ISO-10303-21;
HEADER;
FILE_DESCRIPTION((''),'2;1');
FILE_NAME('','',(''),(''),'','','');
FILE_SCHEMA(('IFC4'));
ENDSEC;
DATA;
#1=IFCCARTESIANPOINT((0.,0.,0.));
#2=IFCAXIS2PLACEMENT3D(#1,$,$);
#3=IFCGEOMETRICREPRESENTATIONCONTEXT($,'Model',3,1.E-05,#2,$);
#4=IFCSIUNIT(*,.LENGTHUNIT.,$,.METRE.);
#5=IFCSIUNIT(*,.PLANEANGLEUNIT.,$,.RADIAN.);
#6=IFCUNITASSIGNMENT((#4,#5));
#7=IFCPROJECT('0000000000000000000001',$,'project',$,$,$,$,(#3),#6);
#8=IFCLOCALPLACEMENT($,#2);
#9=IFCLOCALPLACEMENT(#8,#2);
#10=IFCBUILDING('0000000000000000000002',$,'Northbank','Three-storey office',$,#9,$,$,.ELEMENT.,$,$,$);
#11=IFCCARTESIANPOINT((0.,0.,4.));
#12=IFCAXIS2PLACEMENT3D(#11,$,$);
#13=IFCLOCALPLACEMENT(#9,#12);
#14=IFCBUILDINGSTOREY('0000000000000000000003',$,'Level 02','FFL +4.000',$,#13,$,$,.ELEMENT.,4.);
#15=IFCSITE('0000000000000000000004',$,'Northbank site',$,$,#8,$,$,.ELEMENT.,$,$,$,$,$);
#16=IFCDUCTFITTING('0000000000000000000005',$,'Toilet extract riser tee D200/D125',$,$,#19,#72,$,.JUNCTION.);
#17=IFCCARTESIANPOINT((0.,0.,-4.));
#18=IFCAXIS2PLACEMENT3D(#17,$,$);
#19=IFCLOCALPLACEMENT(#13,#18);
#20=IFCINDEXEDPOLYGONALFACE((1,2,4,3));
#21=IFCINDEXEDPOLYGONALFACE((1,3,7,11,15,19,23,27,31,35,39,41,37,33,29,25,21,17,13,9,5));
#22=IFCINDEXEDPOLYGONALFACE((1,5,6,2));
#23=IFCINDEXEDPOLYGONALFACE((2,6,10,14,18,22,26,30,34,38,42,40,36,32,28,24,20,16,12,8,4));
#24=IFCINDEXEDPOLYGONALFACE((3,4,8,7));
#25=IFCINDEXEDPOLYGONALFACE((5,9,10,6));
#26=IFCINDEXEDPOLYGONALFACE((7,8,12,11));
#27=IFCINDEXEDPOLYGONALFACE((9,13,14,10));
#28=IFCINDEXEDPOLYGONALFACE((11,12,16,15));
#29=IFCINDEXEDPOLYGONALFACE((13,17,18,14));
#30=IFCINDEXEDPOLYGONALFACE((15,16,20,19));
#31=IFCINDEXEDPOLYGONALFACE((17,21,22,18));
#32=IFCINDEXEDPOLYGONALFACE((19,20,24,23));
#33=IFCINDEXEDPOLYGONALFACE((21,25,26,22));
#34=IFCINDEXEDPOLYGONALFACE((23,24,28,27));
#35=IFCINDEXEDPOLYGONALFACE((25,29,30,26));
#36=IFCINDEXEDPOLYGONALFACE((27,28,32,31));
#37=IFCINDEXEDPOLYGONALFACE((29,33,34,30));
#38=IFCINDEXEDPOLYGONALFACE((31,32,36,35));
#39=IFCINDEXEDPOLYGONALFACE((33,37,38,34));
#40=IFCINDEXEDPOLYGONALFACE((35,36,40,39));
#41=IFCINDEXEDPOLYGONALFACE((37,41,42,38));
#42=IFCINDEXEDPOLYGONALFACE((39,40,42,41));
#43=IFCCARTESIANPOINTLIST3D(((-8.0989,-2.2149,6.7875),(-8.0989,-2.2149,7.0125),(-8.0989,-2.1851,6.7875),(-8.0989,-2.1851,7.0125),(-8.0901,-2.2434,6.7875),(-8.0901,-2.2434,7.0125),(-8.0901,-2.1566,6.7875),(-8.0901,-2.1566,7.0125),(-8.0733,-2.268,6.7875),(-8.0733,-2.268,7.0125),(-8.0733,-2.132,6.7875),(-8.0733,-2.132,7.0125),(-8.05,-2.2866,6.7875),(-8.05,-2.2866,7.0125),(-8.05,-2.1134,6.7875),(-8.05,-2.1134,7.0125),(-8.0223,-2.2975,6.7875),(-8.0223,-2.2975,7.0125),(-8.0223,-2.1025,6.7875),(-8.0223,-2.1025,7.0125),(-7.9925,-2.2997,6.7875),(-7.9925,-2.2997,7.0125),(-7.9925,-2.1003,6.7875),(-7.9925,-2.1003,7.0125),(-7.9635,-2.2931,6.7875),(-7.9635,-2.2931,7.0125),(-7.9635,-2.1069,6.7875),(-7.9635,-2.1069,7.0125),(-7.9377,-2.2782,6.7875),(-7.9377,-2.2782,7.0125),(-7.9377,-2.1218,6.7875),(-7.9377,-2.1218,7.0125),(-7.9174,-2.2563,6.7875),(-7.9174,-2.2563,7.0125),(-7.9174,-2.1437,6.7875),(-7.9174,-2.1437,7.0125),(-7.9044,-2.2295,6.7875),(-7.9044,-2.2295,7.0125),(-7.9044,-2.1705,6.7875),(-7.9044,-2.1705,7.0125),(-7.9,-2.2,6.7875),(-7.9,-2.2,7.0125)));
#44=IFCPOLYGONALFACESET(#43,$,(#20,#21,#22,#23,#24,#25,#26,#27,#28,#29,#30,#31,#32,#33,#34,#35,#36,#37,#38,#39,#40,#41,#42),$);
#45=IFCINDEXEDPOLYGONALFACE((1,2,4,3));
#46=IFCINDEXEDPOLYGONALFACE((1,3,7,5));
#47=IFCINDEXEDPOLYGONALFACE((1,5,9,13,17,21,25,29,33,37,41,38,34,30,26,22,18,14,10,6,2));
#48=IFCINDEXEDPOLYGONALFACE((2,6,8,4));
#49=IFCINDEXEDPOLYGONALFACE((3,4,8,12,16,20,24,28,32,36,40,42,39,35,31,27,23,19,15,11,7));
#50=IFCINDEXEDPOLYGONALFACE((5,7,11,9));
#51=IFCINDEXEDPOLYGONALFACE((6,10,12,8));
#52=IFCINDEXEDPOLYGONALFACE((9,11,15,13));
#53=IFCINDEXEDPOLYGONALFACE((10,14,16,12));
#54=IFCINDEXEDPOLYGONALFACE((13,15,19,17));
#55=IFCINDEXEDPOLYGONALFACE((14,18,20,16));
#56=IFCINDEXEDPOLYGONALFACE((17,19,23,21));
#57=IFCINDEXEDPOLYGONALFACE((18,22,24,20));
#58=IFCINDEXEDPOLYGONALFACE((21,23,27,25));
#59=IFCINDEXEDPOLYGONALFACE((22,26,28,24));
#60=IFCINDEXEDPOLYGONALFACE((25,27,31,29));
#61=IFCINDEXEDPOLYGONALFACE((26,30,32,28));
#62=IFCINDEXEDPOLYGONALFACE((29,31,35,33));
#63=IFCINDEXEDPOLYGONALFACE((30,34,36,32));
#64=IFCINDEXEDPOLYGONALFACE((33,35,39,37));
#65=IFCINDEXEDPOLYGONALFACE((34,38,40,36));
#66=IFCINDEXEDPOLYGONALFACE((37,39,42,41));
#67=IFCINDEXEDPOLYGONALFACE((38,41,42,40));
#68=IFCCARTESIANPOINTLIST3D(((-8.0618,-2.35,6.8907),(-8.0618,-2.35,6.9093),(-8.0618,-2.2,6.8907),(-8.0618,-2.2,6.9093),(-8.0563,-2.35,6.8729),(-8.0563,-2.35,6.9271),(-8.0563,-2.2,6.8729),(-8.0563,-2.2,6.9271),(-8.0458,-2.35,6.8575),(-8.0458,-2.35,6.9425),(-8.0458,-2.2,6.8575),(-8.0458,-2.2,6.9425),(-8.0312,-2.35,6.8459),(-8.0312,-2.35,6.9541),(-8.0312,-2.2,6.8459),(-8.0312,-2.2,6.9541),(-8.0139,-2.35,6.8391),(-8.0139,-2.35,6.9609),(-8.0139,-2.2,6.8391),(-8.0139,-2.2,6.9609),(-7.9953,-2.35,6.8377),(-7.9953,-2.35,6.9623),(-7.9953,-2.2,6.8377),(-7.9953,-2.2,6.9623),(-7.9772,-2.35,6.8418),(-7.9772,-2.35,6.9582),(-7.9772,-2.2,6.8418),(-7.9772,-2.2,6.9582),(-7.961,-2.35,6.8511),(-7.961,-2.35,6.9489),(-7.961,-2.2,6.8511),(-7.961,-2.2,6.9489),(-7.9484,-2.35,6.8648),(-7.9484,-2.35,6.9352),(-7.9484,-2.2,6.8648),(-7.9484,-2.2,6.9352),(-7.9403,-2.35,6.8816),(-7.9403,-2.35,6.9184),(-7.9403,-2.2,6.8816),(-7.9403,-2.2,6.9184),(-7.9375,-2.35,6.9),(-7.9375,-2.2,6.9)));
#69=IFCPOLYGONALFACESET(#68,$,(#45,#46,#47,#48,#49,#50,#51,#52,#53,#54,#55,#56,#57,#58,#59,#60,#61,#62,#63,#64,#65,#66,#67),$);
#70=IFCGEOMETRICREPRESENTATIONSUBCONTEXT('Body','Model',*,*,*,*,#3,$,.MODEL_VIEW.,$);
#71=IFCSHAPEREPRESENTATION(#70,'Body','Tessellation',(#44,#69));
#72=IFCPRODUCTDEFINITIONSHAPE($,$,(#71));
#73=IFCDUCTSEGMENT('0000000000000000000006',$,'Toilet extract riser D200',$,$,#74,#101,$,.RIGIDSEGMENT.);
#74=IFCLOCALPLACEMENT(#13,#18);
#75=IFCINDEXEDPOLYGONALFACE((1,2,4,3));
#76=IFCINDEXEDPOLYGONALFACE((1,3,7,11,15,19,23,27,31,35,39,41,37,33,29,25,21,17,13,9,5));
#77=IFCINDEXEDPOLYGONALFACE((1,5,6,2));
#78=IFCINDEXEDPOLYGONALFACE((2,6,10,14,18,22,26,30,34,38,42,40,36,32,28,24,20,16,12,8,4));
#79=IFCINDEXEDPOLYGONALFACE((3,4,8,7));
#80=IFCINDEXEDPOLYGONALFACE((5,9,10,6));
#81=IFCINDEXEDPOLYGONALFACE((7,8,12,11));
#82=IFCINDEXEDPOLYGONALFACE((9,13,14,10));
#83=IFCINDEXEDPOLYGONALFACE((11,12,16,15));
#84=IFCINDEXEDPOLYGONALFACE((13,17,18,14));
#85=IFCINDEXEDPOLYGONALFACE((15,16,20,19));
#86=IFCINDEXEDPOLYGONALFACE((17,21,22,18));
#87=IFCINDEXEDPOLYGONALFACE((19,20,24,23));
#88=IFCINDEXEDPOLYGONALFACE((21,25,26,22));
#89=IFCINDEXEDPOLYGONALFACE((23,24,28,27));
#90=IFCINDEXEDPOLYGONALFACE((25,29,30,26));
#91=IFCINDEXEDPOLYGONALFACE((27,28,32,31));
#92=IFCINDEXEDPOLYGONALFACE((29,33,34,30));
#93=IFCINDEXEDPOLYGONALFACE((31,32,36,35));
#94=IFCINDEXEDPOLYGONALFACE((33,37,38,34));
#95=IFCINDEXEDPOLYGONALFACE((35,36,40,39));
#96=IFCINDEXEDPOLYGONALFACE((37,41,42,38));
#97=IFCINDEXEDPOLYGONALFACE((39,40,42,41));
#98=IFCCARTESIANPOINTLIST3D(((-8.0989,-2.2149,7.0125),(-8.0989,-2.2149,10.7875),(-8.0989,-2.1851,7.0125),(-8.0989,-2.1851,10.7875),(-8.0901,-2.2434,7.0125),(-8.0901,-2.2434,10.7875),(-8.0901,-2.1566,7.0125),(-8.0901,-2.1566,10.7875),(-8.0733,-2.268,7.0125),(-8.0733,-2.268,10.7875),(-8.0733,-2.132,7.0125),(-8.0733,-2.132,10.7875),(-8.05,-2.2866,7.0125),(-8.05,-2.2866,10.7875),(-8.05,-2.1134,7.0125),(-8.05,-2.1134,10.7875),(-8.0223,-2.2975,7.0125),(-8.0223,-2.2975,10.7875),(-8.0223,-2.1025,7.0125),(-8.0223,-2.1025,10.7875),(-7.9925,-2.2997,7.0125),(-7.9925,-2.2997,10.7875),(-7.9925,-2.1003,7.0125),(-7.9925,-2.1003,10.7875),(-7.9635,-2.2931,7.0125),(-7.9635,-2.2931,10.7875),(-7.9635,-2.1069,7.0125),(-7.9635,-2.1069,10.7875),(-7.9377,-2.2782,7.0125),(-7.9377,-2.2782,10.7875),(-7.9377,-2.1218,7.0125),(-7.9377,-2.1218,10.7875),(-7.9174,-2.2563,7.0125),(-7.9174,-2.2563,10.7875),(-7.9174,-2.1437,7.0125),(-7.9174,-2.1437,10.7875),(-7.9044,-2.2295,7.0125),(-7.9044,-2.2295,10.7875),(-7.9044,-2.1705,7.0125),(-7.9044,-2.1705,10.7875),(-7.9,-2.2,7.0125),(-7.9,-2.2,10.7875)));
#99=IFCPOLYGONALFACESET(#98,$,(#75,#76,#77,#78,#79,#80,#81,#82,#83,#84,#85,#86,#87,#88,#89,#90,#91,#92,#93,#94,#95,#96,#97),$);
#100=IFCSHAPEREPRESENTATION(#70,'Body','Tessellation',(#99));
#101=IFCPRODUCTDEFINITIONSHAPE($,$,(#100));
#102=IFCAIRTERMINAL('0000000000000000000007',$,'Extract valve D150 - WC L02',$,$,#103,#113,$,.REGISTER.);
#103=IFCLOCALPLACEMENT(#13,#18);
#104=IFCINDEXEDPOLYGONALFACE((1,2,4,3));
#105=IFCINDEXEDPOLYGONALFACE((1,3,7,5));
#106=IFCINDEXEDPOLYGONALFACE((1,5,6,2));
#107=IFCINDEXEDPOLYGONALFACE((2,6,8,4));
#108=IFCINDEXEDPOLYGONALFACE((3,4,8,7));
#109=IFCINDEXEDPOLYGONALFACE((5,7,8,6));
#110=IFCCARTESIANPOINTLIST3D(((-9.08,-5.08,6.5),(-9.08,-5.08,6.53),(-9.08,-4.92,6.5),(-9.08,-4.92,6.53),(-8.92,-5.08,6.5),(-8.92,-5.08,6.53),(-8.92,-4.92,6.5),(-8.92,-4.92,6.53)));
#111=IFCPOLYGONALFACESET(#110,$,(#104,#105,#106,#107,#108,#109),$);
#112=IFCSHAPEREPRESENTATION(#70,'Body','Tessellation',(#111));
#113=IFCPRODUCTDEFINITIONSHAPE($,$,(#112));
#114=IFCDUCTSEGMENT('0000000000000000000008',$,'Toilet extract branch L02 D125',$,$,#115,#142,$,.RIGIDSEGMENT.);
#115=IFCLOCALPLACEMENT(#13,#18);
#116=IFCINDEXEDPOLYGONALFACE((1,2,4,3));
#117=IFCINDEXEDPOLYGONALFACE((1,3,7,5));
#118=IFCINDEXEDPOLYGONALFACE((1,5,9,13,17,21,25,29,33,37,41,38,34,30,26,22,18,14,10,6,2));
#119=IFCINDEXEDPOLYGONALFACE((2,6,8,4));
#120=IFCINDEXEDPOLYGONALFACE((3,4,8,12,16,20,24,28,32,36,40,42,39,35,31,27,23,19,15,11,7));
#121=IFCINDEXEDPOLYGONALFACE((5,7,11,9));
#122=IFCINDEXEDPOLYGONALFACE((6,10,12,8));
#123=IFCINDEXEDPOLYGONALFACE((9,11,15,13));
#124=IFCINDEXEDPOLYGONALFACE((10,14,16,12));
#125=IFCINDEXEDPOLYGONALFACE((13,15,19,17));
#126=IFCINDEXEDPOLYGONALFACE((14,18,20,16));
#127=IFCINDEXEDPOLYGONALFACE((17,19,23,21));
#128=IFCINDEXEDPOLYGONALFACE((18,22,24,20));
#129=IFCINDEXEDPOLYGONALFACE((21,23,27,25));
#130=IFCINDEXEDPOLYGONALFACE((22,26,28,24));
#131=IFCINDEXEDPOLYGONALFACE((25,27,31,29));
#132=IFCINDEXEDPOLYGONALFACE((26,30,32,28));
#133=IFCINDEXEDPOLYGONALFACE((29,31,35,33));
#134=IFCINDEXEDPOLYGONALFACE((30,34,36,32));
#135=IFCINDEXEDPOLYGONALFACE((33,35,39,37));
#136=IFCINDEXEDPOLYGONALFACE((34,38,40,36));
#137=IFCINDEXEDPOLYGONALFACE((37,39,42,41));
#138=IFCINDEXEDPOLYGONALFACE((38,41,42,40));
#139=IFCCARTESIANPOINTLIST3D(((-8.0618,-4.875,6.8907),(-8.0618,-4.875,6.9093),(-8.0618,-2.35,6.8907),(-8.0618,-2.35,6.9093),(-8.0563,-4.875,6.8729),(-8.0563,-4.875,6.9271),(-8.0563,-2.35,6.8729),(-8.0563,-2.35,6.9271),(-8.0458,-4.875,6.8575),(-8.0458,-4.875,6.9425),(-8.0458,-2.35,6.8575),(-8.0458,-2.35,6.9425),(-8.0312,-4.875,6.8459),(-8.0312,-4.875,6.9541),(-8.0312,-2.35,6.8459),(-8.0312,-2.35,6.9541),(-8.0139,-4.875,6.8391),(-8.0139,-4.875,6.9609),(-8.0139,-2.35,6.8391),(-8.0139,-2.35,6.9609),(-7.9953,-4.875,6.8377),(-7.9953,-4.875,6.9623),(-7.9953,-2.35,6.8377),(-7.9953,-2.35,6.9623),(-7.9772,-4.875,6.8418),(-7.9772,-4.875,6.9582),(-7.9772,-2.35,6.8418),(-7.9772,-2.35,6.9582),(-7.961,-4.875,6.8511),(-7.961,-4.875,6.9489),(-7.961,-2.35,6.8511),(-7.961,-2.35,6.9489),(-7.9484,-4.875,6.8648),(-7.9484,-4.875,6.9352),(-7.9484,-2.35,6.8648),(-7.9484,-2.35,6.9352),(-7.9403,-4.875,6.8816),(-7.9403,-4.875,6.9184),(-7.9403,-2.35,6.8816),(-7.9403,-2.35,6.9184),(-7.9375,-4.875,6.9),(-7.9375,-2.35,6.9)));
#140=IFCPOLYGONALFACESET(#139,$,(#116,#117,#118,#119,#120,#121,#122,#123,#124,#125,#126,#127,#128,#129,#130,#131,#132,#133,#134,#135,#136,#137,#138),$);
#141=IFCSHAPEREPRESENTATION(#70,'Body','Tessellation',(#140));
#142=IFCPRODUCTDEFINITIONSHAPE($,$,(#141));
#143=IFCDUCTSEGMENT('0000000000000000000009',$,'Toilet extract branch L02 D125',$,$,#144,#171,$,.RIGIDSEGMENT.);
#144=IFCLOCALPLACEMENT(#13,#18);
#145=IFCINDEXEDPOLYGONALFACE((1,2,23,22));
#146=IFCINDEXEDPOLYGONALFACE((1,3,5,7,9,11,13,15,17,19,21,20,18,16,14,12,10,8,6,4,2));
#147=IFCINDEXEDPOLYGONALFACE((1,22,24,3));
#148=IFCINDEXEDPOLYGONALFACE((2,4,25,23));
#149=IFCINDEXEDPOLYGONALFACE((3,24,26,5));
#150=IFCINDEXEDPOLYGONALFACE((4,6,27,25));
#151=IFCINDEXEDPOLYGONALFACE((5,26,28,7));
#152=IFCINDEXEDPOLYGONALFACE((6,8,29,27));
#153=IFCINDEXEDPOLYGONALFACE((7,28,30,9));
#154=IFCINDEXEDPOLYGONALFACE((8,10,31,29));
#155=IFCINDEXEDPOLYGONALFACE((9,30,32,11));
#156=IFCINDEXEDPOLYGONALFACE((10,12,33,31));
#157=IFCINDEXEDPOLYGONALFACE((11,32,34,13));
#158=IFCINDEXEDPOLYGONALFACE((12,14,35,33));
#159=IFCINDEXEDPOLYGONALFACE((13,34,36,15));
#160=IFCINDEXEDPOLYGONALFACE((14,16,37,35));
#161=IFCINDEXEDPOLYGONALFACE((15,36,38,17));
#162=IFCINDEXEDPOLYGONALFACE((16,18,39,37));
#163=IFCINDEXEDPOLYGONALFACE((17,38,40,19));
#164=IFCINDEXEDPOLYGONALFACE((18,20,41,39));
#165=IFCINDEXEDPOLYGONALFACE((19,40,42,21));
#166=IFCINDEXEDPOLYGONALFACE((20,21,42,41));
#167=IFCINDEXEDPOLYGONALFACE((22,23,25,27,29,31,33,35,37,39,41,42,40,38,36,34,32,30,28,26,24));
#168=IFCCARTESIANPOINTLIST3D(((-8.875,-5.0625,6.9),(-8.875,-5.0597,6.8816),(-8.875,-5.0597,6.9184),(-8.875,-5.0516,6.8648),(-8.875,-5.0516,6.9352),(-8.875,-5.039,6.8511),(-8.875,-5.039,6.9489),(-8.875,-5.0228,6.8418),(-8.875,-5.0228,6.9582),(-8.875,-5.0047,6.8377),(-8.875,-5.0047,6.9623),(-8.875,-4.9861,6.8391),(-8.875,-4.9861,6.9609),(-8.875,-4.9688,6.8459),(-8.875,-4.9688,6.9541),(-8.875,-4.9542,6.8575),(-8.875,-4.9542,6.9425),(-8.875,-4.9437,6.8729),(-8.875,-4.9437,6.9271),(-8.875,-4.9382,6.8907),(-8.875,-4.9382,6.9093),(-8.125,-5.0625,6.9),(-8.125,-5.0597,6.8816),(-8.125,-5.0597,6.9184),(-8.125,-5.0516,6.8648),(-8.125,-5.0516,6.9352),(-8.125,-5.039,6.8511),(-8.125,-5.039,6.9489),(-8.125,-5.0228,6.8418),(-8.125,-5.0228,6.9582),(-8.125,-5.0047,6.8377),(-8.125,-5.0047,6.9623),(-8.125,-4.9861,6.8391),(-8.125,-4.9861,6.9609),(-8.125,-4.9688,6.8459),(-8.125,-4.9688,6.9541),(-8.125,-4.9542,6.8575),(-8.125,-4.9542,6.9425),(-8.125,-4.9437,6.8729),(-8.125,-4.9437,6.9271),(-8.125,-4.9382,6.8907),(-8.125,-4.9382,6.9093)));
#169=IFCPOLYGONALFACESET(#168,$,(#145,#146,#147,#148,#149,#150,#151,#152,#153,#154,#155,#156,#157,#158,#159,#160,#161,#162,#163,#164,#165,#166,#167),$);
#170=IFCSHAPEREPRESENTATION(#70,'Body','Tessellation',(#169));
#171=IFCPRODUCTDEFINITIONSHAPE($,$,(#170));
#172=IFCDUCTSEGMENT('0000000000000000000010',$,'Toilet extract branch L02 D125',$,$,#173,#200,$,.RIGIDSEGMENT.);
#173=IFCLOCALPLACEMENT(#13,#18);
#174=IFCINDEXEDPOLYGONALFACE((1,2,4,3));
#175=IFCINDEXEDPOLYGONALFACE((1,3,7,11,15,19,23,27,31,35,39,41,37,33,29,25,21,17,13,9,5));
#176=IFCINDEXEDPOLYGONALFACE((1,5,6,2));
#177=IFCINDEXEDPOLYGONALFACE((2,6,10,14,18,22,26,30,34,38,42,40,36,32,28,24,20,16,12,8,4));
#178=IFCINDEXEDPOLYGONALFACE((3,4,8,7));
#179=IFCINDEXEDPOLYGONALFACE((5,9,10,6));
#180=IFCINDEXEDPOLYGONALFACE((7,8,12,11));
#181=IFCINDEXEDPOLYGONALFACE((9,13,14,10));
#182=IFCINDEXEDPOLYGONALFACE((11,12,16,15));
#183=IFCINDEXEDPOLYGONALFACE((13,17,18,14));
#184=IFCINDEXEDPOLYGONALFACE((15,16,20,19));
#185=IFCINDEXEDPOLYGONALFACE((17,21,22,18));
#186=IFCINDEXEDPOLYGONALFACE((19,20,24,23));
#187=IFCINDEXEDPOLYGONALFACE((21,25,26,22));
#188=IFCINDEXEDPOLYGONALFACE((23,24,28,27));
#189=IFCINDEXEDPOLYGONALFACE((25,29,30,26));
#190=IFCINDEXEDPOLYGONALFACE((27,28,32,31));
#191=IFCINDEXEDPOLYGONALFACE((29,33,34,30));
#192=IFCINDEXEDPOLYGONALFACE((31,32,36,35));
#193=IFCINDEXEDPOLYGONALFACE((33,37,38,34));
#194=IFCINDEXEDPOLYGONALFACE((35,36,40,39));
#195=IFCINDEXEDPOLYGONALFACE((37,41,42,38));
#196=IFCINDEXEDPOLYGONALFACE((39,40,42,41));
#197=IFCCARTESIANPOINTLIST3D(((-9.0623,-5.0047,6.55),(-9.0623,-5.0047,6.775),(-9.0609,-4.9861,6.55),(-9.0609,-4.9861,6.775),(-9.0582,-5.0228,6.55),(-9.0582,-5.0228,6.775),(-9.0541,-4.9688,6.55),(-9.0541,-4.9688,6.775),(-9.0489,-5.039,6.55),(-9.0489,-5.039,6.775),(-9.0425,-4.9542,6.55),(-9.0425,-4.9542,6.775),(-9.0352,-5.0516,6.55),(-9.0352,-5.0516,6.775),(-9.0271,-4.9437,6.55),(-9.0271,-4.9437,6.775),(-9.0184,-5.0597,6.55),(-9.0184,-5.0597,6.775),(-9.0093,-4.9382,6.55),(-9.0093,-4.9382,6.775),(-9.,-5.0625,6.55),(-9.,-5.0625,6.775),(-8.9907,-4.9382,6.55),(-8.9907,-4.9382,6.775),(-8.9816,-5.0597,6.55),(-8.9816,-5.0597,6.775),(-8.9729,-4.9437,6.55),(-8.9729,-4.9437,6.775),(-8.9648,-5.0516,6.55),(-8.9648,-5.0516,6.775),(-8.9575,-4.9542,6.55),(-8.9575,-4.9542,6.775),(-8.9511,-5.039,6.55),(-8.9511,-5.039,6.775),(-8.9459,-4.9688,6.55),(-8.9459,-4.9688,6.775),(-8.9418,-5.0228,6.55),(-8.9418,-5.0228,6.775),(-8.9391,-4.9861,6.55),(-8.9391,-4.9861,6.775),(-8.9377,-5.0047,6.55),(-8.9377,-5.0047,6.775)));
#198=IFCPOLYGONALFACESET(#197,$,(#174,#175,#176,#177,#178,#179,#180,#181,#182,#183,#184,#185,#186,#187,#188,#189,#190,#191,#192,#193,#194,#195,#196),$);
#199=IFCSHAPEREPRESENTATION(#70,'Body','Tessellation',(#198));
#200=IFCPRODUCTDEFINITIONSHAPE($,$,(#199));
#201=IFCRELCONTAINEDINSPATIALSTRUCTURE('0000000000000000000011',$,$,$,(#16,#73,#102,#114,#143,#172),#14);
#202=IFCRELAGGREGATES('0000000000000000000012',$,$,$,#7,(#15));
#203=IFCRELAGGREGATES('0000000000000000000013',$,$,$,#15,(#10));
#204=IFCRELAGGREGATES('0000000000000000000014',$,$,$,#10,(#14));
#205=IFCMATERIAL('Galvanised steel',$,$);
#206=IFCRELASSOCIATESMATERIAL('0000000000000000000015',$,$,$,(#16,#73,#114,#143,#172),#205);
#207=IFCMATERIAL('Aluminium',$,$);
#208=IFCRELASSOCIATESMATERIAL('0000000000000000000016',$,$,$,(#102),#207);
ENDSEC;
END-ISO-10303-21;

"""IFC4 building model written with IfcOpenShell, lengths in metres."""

from ifc_helpers import new_model, si_unit, frame, origin, place, context, subcontext, project, spatial, rectangle, circle, extrude, material, element, save


model = new_model("IFC4")

# Units and contexts
model_context = context("Model", 3, precision=1e-05, world=origin())
body_context = subcontext(model_context, "Body", "Model", "MODEL_VIEW")
ifc_project = project(units=[si_unit("LENGTHUNIT", "METRE"), si_unit("PLANEANGLEUNIT", "RADIAN")], contexts=[model_context])

# Site, building, storey
site_placement = place(None, origin())
site = spatial("IfcSite", under=ifc_project, at=site_placement, Name="Northbank site", CompositionType="ELEMENT")
building_placement = place(site_placement, origin())
building = spatial("IfcBuilding", under=site, at=building_placement, Name="Northbank", Description="Three-storey office", CompositionType="ELEMENT")
storey_placement = place(building_placement, frame((0.0, 0.0, 4.0)))
storey = spatial("IfcBuildingStorey", under=building, at=storey_placement, Name="Level 02", Description="FFL +4.000", CompositionType="ELEMENT", Elevation=4.0)

# Shared definitions
ifc_material_1 = material(Name="Galvanised steel")

# Shared definitions
ifc_material_2 = material(Name="Aluminium")

# Duct fitting
duct_fitting_1_placement = place(storey_placement, frame((0.0, 0.0, -4.0)))
element("IfcDuctFitting", 1, at=duct_fitting_1_placement, inside=storey, material=ifc_material_1, Name="Toilet extract riser tee D200/D125", PredefinedType="JUNCTION", context=body_context, shape_type="SweptSolid", body=[
    extrude(circle(Radius=0.1), frame((-8.0, -2.2, 7.0125), z_axis=(0.0, 0.0, -1.0), x_axis=(1.0, 0.0, 0.0)), (0.0, 0.0, 1.0), 0.225),
    extrude(circle(Radius=0.0625), frame((-8.0, -2.2, 6.9), z_axis=(0.0, -1.0, 0.0), x_axis=(1.0, 0.0, 0.0)), (0.0, 0.0, 1.0), 0.15),
])

# Duct segment
duct_segment_1_placement = place(storey_placement, frame((0.0, 0.0, -4.0)))
element("IfcDuctSegment", 2, at=duct_segment_1_placement, inside=storey, material=ifc_material_1, Name="Toilet extract riser D200", PredefinedType="RIGIDSEGMENT", context=body_context, shape_type="SweptSolid", body=[
    extrude(circle(Radius=0.1), frame((-8.0, -2.2, 10.7875), z_axis=(0.0, 0.0, -1.0), x_axis=(1.0, 0.0, 0.0)), (0.0, 0.0, 1.0), 3.775),
])

# Air terminal
air_terminal_1_placement = place(storey_placement, frame((0.0, 0.0, -4.0)))
element("IfcAirTerminal", 3, at=air_terminal_1_placement, inside=storey, material=ifc_material_2, Name="Extract valve D150 - WC L02", PredefinedType="REGISTER", context=body_context, shape_type="SweptSolid", body=[
    extrude(rectangle(XDim=0.16, YDim=0.16), frame((-9.0, -5.0, 6.5)), (0.0, 0.0, 1.0), 0.03),
])

# Duct segments
duct_segment_2_placement = place(storey_placement, frame((0.0, 0.0, -4.0)))
element("IfcDuctSegment", 4, at=duct_segment_2_placement, inside=storey, material=ifc_material_1, Name="Toilet extract branch L02 D125", PredefinedType="RIGIDSEGMENT", context=body_context, shape_type="SweptSolid", body=[
    extrude(circle(Radius=0.0625), frame((-8.0, -2.35, 6.9), z_axis=(0.0, -1.0, 0.0), x_axis=(1.0, 0.0, 0.0)), (0.0, 0.0, 1.0), 2.525),
])
duct_segment_3_placement = place(storey_placement, frame((0.0, 0.0, -4.0)))
element("IfcDuctSegment", 5, at=duct_segment_3_placement, inside=storey, material=ifc_material_1, Name="Toilet extract branch L02 D125", PredefinedType="RIGIDSEGMENT", context=body_context, shape_type="SweptSolid", body=[
    extrude(circle(Radius=0.0625), frame((-8.125, -5.0, 6.9), z_axis=(-1.0, 0.0, 0.0), x_axis=(0.0, -1.0, 0.0)), (0.0, 0.0, 1.0), 0.75),
])
duct_segment_4_placement = place(storey_placement, frame((0.0, 0.0, -4.0)))
element("IfcDuctSegment", 6, at=duct_segment_4_placement, inside=storey, material=ifc_material_1, Name="Toilet extract branch L02 D125", PredefinedType="RIGIDSEGMENT", context=body_context, shape_type="SweptSolid", body=[
    extrude(circle(Radius=0.0625), frame((-9.0, -5.0, 6.775), z_axis=(0.0, 0.0, -1.0), x_axis=(0.0, -1.0, 0.0)), (0.0, 0.0, 1.0), 0.225),
])

save(model, "model.ifc")
